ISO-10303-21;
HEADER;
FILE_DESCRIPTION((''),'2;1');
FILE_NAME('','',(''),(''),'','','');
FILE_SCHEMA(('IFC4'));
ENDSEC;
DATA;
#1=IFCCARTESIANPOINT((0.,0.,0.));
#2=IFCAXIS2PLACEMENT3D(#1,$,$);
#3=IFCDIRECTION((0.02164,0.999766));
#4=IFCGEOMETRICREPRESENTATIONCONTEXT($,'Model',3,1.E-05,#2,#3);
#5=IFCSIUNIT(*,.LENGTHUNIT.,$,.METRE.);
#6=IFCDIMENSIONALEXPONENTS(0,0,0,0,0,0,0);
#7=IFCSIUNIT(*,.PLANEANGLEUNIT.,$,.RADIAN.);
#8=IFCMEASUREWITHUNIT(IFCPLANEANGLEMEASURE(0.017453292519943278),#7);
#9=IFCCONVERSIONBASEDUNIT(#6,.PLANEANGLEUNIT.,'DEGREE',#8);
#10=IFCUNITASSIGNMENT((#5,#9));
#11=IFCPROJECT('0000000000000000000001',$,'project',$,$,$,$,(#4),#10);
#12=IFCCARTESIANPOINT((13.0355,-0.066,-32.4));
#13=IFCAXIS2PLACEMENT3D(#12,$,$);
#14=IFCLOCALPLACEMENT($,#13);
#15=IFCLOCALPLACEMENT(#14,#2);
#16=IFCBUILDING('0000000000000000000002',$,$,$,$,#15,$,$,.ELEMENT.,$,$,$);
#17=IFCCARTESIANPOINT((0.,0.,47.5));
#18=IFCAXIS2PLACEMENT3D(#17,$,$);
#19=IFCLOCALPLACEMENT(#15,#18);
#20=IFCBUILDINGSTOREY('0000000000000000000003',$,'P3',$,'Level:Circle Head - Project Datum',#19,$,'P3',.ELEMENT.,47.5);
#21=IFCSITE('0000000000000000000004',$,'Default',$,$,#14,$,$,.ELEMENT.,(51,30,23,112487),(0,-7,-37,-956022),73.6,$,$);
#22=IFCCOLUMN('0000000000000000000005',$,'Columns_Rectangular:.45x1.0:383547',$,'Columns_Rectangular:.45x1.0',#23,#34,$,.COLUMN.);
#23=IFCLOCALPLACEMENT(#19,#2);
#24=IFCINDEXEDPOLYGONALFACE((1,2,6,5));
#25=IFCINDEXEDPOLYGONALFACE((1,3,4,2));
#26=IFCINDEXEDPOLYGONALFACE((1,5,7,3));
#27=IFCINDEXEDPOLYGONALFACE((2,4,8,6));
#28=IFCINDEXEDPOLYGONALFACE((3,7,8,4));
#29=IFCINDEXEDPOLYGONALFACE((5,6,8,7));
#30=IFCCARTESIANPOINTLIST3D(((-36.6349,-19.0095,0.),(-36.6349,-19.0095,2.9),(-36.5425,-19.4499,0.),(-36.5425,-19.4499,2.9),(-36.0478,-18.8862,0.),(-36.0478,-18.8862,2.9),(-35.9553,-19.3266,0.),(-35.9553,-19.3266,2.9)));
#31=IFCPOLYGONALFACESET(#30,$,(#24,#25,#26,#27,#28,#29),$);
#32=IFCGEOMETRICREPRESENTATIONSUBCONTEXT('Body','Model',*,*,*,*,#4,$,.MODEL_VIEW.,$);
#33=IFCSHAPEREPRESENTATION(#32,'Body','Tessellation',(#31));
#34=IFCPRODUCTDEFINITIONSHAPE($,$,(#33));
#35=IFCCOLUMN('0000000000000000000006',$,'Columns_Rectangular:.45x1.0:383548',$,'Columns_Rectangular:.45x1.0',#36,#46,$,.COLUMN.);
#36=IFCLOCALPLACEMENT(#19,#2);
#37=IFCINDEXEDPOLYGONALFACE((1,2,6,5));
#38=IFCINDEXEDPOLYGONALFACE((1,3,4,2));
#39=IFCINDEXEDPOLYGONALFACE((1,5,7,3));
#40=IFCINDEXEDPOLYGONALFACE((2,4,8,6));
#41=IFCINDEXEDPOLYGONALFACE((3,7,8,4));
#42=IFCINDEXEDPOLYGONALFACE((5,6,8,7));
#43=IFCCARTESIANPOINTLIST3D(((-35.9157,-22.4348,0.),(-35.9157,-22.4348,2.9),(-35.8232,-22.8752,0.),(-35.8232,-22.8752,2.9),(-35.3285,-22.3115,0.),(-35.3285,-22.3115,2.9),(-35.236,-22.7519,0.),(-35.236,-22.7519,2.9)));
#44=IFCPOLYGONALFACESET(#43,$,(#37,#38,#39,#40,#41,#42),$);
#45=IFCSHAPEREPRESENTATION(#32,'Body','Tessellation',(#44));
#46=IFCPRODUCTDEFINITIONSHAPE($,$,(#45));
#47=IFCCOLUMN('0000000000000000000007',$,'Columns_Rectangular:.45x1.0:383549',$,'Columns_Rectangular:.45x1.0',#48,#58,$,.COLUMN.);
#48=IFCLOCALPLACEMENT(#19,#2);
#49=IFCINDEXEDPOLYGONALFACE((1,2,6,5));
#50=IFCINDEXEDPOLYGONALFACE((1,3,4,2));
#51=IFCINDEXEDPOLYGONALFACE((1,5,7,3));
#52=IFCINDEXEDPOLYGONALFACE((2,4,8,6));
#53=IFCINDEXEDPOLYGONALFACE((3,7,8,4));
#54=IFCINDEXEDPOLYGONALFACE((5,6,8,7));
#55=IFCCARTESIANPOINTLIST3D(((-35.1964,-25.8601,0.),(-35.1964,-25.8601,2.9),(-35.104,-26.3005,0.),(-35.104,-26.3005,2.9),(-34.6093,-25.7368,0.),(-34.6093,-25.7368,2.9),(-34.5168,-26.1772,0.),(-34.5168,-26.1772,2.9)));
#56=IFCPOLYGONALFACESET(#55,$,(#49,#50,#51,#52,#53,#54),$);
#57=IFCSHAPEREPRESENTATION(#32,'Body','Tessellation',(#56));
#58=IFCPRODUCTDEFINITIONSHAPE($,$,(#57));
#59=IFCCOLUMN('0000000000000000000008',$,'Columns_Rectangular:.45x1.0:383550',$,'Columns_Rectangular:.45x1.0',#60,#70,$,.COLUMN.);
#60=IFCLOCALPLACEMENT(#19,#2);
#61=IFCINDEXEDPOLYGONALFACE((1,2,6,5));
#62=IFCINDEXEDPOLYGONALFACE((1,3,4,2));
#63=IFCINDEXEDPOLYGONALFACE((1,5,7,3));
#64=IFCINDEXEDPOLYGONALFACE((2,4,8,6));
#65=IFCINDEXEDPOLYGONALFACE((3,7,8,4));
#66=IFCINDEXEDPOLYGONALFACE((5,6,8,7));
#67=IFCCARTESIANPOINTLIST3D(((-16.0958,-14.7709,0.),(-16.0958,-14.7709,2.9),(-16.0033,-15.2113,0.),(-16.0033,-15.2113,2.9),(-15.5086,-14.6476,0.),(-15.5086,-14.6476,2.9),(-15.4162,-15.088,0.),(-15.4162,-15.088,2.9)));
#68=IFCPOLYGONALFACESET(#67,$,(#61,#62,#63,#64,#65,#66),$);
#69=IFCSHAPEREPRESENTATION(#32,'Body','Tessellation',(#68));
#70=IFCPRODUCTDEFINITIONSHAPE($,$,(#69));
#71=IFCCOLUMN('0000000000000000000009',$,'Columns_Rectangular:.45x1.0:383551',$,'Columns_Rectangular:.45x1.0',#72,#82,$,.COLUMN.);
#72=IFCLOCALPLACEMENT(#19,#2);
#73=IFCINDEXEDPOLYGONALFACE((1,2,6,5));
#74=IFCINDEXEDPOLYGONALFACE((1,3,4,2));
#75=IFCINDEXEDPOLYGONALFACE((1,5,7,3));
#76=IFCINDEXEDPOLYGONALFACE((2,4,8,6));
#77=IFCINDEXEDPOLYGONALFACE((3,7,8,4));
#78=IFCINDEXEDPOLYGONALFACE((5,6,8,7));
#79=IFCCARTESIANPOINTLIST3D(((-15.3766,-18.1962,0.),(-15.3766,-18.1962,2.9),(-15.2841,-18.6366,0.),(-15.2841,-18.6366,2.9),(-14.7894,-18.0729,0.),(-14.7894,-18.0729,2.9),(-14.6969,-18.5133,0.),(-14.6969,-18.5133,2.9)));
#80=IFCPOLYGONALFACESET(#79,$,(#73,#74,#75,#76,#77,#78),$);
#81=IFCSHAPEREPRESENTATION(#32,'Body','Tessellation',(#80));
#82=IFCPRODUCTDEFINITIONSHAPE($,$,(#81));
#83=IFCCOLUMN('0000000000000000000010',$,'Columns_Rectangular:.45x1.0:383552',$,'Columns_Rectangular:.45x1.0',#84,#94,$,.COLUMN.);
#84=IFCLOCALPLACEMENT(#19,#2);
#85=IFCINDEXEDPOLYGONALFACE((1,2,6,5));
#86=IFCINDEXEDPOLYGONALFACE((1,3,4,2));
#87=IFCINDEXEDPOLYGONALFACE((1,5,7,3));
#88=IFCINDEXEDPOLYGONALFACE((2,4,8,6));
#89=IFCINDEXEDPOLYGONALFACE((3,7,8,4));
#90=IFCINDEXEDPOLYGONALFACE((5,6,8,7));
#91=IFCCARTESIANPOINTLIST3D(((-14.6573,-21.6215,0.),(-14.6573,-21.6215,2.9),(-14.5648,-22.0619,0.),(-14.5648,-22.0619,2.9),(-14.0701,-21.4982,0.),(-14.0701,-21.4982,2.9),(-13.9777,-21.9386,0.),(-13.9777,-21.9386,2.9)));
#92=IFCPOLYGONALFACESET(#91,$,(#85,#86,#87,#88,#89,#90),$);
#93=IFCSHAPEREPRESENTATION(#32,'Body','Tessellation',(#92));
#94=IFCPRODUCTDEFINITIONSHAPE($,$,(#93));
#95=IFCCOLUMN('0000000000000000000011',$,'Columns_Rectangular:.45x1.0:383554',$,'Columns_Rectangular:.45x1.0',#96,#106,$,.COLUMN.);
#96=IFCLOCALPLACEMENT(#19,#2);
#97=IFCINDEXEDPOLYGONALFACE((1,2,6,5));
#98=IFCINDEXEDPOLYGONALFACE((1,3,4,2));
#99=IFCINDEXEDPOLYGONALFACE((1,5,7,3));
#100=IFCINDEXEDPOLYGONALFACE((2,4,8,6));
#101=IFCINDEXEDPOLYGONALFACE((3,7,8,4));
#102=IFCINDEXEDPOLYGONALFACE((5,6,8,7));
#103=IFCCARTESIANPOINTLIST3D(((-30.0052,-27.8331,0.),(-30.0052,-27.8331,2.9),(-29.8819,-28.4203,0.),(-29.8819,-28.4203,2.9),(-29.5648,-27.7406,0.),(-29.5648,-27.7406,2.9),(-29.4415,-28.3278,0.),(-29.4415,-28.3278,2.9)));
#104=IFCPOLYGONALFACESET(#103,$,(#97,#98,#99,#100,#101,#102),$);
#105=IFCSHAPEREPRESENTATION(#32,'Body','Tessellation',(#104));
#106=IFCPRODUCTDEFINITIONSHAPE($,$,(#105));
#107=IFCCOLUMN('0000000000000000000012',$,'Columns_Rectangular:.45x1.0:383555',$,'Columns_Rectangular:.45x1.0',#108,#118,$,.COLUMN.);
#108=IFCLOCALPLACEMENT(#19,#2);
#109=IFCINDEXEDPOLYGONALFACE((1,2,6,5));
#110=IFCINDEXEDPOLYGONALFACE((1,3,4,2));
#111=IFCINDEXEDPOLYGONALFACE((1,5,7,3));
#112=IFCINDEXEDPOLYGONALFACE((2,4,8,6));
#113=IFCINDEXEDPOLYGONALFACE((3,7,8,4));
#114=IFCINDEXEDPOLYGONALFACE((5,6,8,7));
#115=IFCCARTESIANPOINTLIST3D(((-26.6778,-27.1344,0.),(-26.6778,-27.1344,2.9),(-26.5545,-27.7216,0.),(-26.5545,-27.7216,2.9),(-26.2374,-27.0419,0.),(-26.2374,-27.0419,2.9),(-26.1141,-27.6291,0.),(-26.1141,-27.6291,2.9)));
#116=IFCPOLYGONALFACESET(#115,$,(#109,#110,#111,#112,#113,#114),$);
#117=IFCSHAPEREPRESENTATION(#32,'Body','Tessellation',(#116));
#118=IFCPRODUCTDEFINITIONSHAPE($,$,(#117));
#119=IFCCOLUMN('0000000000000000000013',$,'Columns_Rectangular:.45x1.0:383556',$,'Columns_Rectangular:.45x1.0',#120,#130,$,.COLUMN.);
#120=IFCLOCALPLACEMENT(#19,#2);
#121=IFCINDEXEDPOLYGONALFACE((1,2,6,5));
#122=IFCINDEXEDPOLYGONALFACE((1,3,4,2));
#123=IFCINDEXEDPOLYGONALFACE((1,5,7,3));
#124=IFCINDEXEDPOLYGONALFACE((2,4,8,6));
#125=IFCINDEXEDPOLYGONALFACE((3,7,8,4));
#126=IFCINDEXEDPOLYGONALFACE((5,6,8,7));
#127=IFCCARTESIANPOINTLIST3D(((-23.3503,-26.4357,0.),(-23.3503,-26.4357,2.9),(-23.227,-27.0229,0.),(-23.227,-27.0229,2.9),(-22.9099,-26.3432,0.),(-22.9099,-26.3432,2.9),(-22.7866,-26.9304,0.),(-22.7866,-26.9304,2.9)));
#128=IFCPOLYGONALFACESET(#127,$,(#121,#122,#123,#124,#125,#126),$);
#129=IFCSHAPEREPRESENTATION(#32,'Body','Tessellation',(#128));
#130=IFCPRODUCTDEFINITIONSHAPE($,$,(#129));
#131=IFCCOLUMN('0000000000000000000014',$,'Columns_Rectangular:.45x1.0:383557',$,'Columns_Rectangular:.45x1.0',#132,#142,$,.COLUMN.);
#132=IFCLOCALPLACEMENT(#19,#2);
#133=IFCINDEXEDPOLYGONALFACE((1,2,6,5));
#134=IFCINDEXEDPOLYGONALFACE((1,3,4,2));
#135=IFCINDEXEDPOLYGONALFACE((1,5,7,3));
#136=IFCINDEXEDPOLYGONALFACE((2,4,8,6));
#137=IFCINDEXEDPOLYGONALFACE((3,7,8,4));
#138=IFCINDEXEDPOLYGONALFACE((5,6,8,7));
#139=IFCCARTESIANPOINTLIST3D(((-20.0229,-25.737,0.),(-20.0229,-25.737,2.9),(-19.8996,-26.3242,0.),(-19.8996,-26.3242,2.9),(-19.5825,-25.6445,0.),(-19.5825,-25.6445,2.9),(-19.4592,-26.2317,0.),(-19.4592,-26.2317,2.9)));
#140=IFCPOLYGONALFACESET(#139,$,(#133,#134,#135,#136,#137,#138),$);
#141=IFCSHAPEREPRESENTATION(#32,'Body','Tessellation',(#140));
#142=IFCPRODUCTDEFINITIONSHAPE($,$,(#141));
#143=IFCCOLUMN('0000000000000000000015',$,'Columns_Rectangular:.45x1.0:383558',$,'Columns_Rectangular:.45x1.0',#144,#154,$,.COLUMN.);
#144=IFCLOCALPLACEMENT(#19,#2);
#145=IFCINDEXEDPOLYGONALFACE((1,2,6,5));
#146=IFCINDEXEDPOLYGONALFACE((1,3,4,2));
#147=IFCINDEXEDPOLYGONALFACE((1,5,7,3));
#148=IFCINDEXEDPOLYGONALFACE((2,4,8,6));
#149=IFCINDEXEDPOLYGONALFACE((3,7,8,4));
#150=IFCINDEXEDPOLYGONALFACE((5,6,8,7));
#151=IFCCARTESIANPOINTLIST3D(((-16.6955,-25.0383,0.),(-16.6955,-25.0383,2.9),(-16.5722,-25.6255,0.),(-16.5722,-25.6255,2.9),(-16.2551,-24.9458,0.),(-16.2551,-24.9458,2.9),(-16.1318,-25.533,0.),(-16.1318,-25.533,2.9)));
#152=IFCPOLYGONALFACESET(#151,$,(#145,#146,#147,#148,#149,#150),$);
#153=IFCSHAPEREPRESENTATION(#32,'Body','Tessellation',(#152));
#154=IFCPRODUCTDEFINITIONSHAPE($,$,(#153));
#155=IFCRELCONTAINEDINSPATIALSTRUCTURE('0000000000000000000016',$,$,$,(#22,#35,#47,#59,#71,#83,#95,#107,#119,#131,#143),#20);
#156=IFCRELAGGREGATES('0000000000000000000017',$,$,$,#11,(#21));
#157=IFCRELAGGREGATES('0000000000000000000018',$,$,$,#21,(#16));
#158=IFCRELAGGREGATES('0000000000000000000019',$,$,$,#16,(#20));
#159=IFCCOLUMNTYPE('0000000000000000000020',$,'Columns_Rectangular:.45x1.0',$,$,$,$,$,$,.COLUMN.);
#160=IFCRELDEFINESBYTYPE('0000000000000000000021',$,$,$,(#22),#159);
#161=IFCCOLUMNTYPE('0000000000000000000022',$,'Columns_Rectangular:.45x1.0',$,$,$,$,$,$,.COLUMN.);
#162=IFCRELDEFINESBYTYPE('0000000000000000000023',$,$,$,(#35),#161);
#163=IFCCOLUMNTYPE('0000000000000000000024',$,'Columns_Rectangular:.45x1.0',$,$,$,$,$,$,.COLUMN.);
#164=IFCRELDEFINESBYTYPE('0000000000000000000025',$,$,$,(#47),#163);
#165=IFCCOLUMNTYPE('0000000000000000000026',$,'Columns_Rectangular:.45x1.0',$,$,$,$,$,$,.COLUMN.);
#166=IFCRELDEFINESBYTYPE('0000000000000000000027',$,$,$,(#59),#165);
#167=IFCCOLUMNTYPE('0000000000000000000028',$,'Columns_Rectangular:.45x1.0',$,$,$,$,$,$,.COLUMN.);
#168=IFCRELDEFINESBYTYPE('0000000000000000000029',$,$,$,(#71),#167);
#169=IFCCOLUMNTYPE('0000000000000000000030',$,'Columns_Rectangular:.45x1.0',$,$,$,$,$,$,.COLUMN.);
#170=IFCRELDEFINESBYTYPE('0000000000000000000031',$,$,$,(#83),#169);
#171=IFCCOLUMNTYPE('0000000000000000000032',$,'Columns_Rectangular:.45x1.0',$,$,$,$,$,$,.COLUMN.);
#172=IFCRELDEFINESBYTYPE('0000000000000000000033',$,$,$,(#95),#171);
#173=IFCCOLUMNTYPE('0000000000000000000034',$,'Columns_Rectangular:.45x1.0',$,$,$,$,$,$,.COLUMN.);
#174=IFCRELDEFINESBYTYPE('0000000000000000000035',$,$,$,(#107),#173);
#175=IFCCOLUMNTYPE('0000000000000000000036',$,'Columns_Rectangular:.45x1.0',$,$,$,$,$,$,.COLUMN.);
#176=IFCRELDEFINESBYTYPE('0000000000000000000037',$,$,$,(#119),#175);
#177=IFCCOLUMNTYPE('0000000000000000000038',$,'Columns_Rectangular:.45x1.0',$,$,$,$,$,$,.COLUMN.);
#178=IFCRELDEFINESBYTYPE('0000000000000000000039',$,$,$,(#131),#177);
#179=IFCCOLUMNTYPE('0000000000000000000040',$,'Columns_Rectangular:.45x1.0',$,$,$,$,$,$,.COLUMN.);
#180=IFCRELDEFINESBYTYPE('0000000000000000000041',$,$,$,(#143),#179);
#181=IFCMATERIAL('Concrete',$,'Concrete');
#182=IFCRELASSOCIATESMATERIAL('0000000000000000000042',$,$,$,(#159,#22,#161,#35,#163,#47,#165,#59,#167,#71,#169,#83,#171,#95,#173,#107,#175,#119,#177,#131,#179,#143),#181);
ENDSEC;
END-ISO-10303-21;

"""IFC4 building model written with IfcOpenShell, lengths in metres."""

from ifc_helpers import new_model, entity, si_unit, converted_unit, direction, frame, origin, place, context, subcontext, project, spatial, indexed_curve, outline, extrude, source, transform, mapped, material, type_object, type_shapes, element, save


model = new_model("IFC4")

# Units and contexts
model_context = context("Model", 3, precision=1e-05, world=origin(), true_north=direction((0.02164, 0.999766)))
body_context = subcontext(model_context, "Body", "Model", "MODEL_VIEW")
ifc_project = project(units=[si_unit("LENGTHUNIT", "METRE"), converted_unit("PLANEANGLEUNIT", "DEGREE", entity("IfcPlaneAngleMeasure", 0.017453292519943278), si_unit("PLANEANGLEUNIT", "RADIAN"), dimensions=[0, 0, 0, 0, 0, 0, 0])], contexts=[model_context])

# Site, building, storey
site_placement = place(None, frame((13.0355, -0.066, -32.4)))
site = spatial("IfcSite", under=ifc_project, at=site_placement, Name="Default", CompositionType="ELEMENT", RefLatitude=(51, 30, 23, 112487), RefLongitude=(0, -7, -37, -956022), RefElevation=73.6)
building_placement = place(site_placement, origin())
building = spatial("IfcBuilding", under=site, at=building_placement, CompositionType="ELEMENT")
storey_placement = place(building_placement, frame((0.0, 0.0, 47.5)))
storey = spatial("IfcBuildingStorey", under=building, at=storey_placement, Name="P3", ObjectType="Level:Circle Head - Project Datum", LongName="P3", CompositionType="ELEMENT", Elevation=47.5)

# Columns
ifc_material = material(Name="Concrete", Category="Concrete")
column_type_1 = type_object("IfcColumnType", Name="Columns_Rectangular:.45x1.0", PredefinedType="COLUMN", material=ifc_material)
shared_shape_1 = source(origin(), body_context, "Body", "SweptSolid", [
    extrude(outline(indexed_curve([(-0.3, -0.225), (0.3, -0.225), (0.3, 0.225), (-0.3, 0.225), (-0.3, -0.225)], self_intersect=False)), frame((-36.2951, -19.168, 47.5), z_axis=(0.0, 0.0, 1.0), x_axis=(0.978657, 0.2055, 0.0)), (0.0, 0.0, 1.0), 2.9),
])
type_shapes(column_type_1, [shared_shape_1])
column_1_placement = place(storey_placement, frame((0.0, 0.0, -47.5)))
element("IfcColumn", 1, at=column_1_placement, inside=storey, type_object=column_type_1, material=ifc_material, Name="Columns_Rectangular:.45x1.0:383547", ObjectType="Columns_Rectangular:.45x1.0", PredefinedType="COLUMN", context=body_context, shape_type="MappedRepresentation", body=[
    mapped(shared_shape_1, transform((0.0, 0.0, 0.0), scale=1.0)),
])
column_type_2 = type_object("IfcColumnType", Name="Columns_Rectangular:.45x1.0", PredefinedType="COLUMN", material=ifc_material)
shared_shape_2 = source(origin(), body_context, "Body", "SweptSolid", [
    extrude(outline(indexed_curve([(-0.3, -0.225), (0.3, -0.225), (0.3, 0.225), (-0.3, 0.225), (-0.3, -0.225)], self_intersect=False)), frame((-35.5759, -22.5933, 47.5), z_axis=(0.0, 0.0, 1.0), x_axis=(0.978657, 0.2055, 0.0)), (0.0, 0.0, 1.0), 2.9),
])
type_shapes(column_type_2, [shared_shape_2])
column_2_placement = place(storey_placement, frame((0.0, 0.0, -47.5)))
element("IfcColumn", 2, at=column_2_placement, inside=storey, type_object=column_type_2, material=ifc_material, Name="Columns_Rectangular:.45x1.0:383548", ObjectType="Columns_Rectangular:.45x1.0", PredefinedType="COLUMN", context=body_context, shape_type="MappedRepresentation", body=[
    mapped(shared_shape_2, transform((0.0, 0.0, 0.0), scale=1.0)),
])
column_type_3 = type_object("IfcColumnType", Name="Columns_Rectangular:.45x1.0", PredefinedType="COLUMN", material=ifc_material)
shared_shape_3 = source(origin(), body_context, "Body", "SweptSolid", [
    extrude(outline(indexed_curve([(-0.3, -0.225), (0.3, -0.225), (0.3, 0.225), (-0.3, 0.225), (-0.3, -0.225)], self_intersect=False)), frame((-34.8566, -26.0186, 47.5), z_axis=(0.0, 0.0, 1.0), x_axis=(0.978657, 0.2055, 0.0)), (0.0, 0.0, 1.0), 2.9),
])
type_shapes(column_type_3, [shared_shape_3])
column_3_placement = place(storey_placement, frame((0.0, 0.0, -47.5)))
element("IfcColumn", 3, at=column_3_placement, inside=storey, type_object=column_type_3, material=ifc_material, Name="Columns_Rectangular:.45x1.0:383549", ObjectType="Columns_Rectangular:.45x1.0", PredefinedType="COLUMN", context=body_context, shape_type="MappedRepresentation", body=[
    mapped(shared_shape_3, transform((0.0, 0.0, 0.0), scale=1.0)),
])
column_type_4 = type_object("IfcColumnType", Name="Columns_Rectangular:.45x1.0", PredefinedType="COLUMN", material=ifc_material)
shared_shape_4 = source(origin(), body_context, "Body", "SweptSolid", [
    extrude(outline(indexed_curve([(-0.3, -0.225), (0.3, -0.225), (0.3, 0.225), (-0.3, 0.225), (-0.3, -0.225)], self_intersect=False)), frame((-15.756, -14.9295, 47.5), z_axis=(0.0, 0.0, 1.0), x_axis=(0.978657, 0.2055, 0.0)), (0.0, 0.0, 1.0), 2.9),
])
type_shapes(column_type_4, [shared_shape_4])
column_4_placement = place(storey_placement, frame((0.0, 0.0, -47.5)))
element("IfcColumn", 4, at=column_4_placement, inside=storey, type_object=column_type_4, material=ifc_material, Name="Columns_Rectangular:.45x1.0:383550", ObjectType="Columns_Rectangular:.45x1.0", PredefinedType="COLUMN", context=body_context, shape_type="MappedRepresentation", body=[
    mapped(shared_shape_4, transform((0.0, 0.0, 0.0), scale=1.0)),
])
column_type_5 = type_object("IfcColumnType", Name="Columns_Rectangular:.45x1.0", PredefinedType="COLUMN", material=ifc_material)
shared_shape_5 = source(origin(), body_context, "Body", "SweptSolid", [
    extrude(outline(indexed_curve([(-0.3, -0.225), (0.3, -0.225), (0.3, 0.225), (-0.3, 0.225), (-0.3, -0.225)], self_intersect=False)), frame((-15.0367, -18.3548, 47.5), z_axis=(0.0, 0.0, 1.0), x_axis=(0.978657, 0.2055, 0.0)), (0.0, 0.0, 1.0), 2.9),
])
type_shapes(column_type_5, [shared_shape_5])
column_5_placement = place(storey_placement, frame((0.0, 0.0, -47.5)))
element("IfcColumn", 5, at=column_5_placement, inside=storey, type_object=column_type_5, material=ifc_material, Name="Columns_Rectangular:.45x1.0:383551", ObjectType="Columns_Rectangular:.45x1.0", PredefinedType="COLUMN", context=body_context, shape_type="MappedRepresentation", body=[
    mapped(shared_shape_5, transform((0.0, 0.0, 0.0), scale=1.0)),
])
column_type_6 = type_object("IfcColumnType", Name="Columns_Rectangular:.45x1.0", PredefinedType="COLUMN", material=ifc_material)
shared_shape_6 = source(origin(), body_context, "Body", "SweptSolid", [
    extrude(outline(indexed_curve([(-0.3, -0.225), (0.3, -0.225), (0.3, 0.225), (-0.3, 0.225), (-0.3, -0.225)], self_intersect=False)), frame((-14.3175, -21.7801, 47.5), z_axis=(0.0, 0.0, 1.0), x_axis=(0.978657, 0.2055, 0.0)), (0.0, 0.0, 1.0), 2.9),
])
type_shapes(column_type_6, [shared_shape_6])
column_6_placement = place(storey_placement, frame((0.0, 0.0, -47.5)))
element("IfcColumn", 6, at=column_6_placement, inside=storey, type_object=column_type_6, material=ifc_material, Name="Columns_Rectangular:.45x1.0:383552", ObjectType="Columns_Rectangular:.45x1.0", PredefinedType="COLUMN", context=body_context, shape_type="MappedRepresentation", body=[
    mapped(shared_shape_6, transform((0.0, 0.0, 0.0), scale=1.0)),
])
column_type_7 = type_object("IfcColumnType", Name="Columns_Rectangular:.45x1.0", PredefinedType="COLUMN", material=ifc_material)
shared_shape_7 = source(origin(), body_context, "Body", "SweptSolid", [
    extrude(outline(indexed_curve([(-0.3, -0.225), (0.3, -0.225), (0.3, 0.225), (-0.3, 0.225), (-0.3, -0.225)], self_intersect=False)), frame((-29.7234, -28.0804, 47.5), z_axis=(0.0, 0.0, 1.0), x_axis=(0.2055, -0.978657, 0.0)), (0.0, 0.0, 1.0), 2.9),
])
type_shapes(column_type_7, [shared_shape_7])
column_7_placement = place(storey_placement, frame((0.0, 0.0, -47.5)))
element("IfcColumn", 7, at=column_7_placement, inside=storey, type_object=column_type_7, material=ifc_material, Name="Columns_Rectangular:.45x1.0:383554", ObjectType="Columns_Rectangular:.45x1.0", PredefinedType="COLUMN", context=body_context, shape_type="MappedRepresentation", body=[
    mapped(shared_shape_7, transform((0.0, 0.0, 0.0), scale=1.0)),
])
column_type_8 = type_object("IfcColumnType", Name="Columns_Rectangular:.45x1.0", PredefinedType="COLUMN", material=ifc_material)
shared_shape_8 = source(origin(), body_context, "Body", "SweptSolid", [
    extrude(outline(indexed_curve([(-0.3, -0.225), (0.3, -0.225), (0.3, 0.225), (-0.3, 0.225), (-0.3, -0.225)], self_intersect=False)), frame((-26.3959, -27.3817, 47.5), z_axis=(0.0, 0.0, 1.0), x_axis=(0.2055, -0.978657, 0.0)), (0.0, 0.0, 1.0), 2.9),
])
type_shapes(column_type_8, [shared_shape_8])
column_8_placement = place(storey_placement, frame((0.0, 0.0, -47.5)))
element("IfcColumn", 8, at=column_8_placement, inside=storey, type_object=column_type_8, material=ifc_material, Name="Columns_Rectangular:.45x1.0:383555", ObjectType="Columns_Rectangular:.45x1.0", PredefinedType="COLUMN", context=body_context, shape_type="MappedRepresentation", body=[
    mapped(shared_shape_8, transform((0.0, 0.0, 0.0), scale=1.0)),
])
column_type_9 = type_object("IfcColumnType", Name="Columns_Rectangular:.45x1.0", PredefinedType="COLUMN", material=ifc_material)
shared_shape_9 = source(origin(), body_context, "Body", "SweptSolid", [
    extrude(outline(indexed_curve([(-0.3, -0.225), (0.3, -0.225), (0.3, 0.225), (-0.3, 0.225), (-0.3, -0.225)], self_intersect=False)), frame((-23.0685, -26.6831, 47.5), z_axis=(0.0, 0.0, 1.0), x_axis=(0.2055, -0.978657, 0.0)), (0.0, 0.0, 1.0), 2.9),
])
type_shapes(column_type_9, [shared_shape_9])
column_9_placement = place(storey_placement, frame((0.0, 0.0, -47.5)))
element("IfcColumn", 9, at=column_9_placement, inside=storey, type_object=column_type_9, material=ifc_material, Name="Columns_Rectangular:.45x1.0:383556", ObjectType="Columns_Rectangular:.45x1.0", PredefinedType="COLUMN", context=body_context, shape_type="MappedRepresentation", body=[
    mapped(shared_shape_9, transform((0.0, 0.0, 0.0), scale=1.0)),
])
column_type_10 = type_object("IfcColumnType", Name="Columns_Rectangular:.45x1.0", PredefinedType="COLUMN", material=ifc_material)
shared_shape_10 = source(origin(), body_context, "Body", "SweptSolid", [
    extrude(outline(indexed_curve([(-0.3, -0.225), (0.3, -0.225), (0.3, 0.225), (-0.3, 0.225), (-0.3, -0.225)], self_intersect=False)), frame((-19.741, -25.9844, 47.5), z_axis=(0.0, 0.0, 1.0), x_axis=(0.2055, -0.978657, 0.0)), (0.0, 0.0, 1.0), 2.9),
])
type_shapes(column_type_10, [shared_shape_10])
column_10_placement = place(storey_placement, frame((0.0, 0.0, -47.5)))
element("IfcColumn", 10, at=column_10_placement, inside=storey, type_object=column_type_10, material=ifc_material, Name="Columns_Rectangular:.45x1.0:383557", ObjectType="Columns_Rectangular:.45x1.0", PredefinedType="COLUMN", context=body_context, shape_type="MappedRepresentation", body=[
    mapped(shared_shape_10, transform((0.0, 0.0, 0.0), scale=1.0)),
])
column_type_11 = type_object("IfcColumnType", Name="Columns_Rectangular:.45x1.0", PredefinedType="COLUMN", material=ifc_material)
shared_shape_11 = source(origin(), body_context, "Body", "SweptSolid", [
    extrude(outline(indexed_curve([(-0.3, -0.225), (0.3, -0.225), (0.3, 0.225), (-0.3, 0.225), (-0.3, -0.225)], self_intersect=False)), frame((-16.4136, -25.2857, 47.5), z_axis=(0.0, 0.0, 1.0), x_axis=(0.2055, -0.978657, 0.0)), (0.0, 0.0, 1.0), 2.9),
])
type_shapes(column_type_11, [shared_shape_11])
column_11_placement = place(storey_placement, frame((0.0, 0.0, -47.5)))
element("IfcColumn", 11, at=column_11_placement, inside=storey, type_object=column_type_11, material=ifc_material, Name="Columns_Rectangular:.45x1.0:383558", ObjectType="Columns_Rectangular:.45x1.0", PredefinedType="COLUMN", context=body_context, shape_type="MappedRepresentation", body=[
    mapped(shared_shape_11, transform((0.0, 0.0, 0.0), scale=1.0)),
])

save(model, "model.ifc")
